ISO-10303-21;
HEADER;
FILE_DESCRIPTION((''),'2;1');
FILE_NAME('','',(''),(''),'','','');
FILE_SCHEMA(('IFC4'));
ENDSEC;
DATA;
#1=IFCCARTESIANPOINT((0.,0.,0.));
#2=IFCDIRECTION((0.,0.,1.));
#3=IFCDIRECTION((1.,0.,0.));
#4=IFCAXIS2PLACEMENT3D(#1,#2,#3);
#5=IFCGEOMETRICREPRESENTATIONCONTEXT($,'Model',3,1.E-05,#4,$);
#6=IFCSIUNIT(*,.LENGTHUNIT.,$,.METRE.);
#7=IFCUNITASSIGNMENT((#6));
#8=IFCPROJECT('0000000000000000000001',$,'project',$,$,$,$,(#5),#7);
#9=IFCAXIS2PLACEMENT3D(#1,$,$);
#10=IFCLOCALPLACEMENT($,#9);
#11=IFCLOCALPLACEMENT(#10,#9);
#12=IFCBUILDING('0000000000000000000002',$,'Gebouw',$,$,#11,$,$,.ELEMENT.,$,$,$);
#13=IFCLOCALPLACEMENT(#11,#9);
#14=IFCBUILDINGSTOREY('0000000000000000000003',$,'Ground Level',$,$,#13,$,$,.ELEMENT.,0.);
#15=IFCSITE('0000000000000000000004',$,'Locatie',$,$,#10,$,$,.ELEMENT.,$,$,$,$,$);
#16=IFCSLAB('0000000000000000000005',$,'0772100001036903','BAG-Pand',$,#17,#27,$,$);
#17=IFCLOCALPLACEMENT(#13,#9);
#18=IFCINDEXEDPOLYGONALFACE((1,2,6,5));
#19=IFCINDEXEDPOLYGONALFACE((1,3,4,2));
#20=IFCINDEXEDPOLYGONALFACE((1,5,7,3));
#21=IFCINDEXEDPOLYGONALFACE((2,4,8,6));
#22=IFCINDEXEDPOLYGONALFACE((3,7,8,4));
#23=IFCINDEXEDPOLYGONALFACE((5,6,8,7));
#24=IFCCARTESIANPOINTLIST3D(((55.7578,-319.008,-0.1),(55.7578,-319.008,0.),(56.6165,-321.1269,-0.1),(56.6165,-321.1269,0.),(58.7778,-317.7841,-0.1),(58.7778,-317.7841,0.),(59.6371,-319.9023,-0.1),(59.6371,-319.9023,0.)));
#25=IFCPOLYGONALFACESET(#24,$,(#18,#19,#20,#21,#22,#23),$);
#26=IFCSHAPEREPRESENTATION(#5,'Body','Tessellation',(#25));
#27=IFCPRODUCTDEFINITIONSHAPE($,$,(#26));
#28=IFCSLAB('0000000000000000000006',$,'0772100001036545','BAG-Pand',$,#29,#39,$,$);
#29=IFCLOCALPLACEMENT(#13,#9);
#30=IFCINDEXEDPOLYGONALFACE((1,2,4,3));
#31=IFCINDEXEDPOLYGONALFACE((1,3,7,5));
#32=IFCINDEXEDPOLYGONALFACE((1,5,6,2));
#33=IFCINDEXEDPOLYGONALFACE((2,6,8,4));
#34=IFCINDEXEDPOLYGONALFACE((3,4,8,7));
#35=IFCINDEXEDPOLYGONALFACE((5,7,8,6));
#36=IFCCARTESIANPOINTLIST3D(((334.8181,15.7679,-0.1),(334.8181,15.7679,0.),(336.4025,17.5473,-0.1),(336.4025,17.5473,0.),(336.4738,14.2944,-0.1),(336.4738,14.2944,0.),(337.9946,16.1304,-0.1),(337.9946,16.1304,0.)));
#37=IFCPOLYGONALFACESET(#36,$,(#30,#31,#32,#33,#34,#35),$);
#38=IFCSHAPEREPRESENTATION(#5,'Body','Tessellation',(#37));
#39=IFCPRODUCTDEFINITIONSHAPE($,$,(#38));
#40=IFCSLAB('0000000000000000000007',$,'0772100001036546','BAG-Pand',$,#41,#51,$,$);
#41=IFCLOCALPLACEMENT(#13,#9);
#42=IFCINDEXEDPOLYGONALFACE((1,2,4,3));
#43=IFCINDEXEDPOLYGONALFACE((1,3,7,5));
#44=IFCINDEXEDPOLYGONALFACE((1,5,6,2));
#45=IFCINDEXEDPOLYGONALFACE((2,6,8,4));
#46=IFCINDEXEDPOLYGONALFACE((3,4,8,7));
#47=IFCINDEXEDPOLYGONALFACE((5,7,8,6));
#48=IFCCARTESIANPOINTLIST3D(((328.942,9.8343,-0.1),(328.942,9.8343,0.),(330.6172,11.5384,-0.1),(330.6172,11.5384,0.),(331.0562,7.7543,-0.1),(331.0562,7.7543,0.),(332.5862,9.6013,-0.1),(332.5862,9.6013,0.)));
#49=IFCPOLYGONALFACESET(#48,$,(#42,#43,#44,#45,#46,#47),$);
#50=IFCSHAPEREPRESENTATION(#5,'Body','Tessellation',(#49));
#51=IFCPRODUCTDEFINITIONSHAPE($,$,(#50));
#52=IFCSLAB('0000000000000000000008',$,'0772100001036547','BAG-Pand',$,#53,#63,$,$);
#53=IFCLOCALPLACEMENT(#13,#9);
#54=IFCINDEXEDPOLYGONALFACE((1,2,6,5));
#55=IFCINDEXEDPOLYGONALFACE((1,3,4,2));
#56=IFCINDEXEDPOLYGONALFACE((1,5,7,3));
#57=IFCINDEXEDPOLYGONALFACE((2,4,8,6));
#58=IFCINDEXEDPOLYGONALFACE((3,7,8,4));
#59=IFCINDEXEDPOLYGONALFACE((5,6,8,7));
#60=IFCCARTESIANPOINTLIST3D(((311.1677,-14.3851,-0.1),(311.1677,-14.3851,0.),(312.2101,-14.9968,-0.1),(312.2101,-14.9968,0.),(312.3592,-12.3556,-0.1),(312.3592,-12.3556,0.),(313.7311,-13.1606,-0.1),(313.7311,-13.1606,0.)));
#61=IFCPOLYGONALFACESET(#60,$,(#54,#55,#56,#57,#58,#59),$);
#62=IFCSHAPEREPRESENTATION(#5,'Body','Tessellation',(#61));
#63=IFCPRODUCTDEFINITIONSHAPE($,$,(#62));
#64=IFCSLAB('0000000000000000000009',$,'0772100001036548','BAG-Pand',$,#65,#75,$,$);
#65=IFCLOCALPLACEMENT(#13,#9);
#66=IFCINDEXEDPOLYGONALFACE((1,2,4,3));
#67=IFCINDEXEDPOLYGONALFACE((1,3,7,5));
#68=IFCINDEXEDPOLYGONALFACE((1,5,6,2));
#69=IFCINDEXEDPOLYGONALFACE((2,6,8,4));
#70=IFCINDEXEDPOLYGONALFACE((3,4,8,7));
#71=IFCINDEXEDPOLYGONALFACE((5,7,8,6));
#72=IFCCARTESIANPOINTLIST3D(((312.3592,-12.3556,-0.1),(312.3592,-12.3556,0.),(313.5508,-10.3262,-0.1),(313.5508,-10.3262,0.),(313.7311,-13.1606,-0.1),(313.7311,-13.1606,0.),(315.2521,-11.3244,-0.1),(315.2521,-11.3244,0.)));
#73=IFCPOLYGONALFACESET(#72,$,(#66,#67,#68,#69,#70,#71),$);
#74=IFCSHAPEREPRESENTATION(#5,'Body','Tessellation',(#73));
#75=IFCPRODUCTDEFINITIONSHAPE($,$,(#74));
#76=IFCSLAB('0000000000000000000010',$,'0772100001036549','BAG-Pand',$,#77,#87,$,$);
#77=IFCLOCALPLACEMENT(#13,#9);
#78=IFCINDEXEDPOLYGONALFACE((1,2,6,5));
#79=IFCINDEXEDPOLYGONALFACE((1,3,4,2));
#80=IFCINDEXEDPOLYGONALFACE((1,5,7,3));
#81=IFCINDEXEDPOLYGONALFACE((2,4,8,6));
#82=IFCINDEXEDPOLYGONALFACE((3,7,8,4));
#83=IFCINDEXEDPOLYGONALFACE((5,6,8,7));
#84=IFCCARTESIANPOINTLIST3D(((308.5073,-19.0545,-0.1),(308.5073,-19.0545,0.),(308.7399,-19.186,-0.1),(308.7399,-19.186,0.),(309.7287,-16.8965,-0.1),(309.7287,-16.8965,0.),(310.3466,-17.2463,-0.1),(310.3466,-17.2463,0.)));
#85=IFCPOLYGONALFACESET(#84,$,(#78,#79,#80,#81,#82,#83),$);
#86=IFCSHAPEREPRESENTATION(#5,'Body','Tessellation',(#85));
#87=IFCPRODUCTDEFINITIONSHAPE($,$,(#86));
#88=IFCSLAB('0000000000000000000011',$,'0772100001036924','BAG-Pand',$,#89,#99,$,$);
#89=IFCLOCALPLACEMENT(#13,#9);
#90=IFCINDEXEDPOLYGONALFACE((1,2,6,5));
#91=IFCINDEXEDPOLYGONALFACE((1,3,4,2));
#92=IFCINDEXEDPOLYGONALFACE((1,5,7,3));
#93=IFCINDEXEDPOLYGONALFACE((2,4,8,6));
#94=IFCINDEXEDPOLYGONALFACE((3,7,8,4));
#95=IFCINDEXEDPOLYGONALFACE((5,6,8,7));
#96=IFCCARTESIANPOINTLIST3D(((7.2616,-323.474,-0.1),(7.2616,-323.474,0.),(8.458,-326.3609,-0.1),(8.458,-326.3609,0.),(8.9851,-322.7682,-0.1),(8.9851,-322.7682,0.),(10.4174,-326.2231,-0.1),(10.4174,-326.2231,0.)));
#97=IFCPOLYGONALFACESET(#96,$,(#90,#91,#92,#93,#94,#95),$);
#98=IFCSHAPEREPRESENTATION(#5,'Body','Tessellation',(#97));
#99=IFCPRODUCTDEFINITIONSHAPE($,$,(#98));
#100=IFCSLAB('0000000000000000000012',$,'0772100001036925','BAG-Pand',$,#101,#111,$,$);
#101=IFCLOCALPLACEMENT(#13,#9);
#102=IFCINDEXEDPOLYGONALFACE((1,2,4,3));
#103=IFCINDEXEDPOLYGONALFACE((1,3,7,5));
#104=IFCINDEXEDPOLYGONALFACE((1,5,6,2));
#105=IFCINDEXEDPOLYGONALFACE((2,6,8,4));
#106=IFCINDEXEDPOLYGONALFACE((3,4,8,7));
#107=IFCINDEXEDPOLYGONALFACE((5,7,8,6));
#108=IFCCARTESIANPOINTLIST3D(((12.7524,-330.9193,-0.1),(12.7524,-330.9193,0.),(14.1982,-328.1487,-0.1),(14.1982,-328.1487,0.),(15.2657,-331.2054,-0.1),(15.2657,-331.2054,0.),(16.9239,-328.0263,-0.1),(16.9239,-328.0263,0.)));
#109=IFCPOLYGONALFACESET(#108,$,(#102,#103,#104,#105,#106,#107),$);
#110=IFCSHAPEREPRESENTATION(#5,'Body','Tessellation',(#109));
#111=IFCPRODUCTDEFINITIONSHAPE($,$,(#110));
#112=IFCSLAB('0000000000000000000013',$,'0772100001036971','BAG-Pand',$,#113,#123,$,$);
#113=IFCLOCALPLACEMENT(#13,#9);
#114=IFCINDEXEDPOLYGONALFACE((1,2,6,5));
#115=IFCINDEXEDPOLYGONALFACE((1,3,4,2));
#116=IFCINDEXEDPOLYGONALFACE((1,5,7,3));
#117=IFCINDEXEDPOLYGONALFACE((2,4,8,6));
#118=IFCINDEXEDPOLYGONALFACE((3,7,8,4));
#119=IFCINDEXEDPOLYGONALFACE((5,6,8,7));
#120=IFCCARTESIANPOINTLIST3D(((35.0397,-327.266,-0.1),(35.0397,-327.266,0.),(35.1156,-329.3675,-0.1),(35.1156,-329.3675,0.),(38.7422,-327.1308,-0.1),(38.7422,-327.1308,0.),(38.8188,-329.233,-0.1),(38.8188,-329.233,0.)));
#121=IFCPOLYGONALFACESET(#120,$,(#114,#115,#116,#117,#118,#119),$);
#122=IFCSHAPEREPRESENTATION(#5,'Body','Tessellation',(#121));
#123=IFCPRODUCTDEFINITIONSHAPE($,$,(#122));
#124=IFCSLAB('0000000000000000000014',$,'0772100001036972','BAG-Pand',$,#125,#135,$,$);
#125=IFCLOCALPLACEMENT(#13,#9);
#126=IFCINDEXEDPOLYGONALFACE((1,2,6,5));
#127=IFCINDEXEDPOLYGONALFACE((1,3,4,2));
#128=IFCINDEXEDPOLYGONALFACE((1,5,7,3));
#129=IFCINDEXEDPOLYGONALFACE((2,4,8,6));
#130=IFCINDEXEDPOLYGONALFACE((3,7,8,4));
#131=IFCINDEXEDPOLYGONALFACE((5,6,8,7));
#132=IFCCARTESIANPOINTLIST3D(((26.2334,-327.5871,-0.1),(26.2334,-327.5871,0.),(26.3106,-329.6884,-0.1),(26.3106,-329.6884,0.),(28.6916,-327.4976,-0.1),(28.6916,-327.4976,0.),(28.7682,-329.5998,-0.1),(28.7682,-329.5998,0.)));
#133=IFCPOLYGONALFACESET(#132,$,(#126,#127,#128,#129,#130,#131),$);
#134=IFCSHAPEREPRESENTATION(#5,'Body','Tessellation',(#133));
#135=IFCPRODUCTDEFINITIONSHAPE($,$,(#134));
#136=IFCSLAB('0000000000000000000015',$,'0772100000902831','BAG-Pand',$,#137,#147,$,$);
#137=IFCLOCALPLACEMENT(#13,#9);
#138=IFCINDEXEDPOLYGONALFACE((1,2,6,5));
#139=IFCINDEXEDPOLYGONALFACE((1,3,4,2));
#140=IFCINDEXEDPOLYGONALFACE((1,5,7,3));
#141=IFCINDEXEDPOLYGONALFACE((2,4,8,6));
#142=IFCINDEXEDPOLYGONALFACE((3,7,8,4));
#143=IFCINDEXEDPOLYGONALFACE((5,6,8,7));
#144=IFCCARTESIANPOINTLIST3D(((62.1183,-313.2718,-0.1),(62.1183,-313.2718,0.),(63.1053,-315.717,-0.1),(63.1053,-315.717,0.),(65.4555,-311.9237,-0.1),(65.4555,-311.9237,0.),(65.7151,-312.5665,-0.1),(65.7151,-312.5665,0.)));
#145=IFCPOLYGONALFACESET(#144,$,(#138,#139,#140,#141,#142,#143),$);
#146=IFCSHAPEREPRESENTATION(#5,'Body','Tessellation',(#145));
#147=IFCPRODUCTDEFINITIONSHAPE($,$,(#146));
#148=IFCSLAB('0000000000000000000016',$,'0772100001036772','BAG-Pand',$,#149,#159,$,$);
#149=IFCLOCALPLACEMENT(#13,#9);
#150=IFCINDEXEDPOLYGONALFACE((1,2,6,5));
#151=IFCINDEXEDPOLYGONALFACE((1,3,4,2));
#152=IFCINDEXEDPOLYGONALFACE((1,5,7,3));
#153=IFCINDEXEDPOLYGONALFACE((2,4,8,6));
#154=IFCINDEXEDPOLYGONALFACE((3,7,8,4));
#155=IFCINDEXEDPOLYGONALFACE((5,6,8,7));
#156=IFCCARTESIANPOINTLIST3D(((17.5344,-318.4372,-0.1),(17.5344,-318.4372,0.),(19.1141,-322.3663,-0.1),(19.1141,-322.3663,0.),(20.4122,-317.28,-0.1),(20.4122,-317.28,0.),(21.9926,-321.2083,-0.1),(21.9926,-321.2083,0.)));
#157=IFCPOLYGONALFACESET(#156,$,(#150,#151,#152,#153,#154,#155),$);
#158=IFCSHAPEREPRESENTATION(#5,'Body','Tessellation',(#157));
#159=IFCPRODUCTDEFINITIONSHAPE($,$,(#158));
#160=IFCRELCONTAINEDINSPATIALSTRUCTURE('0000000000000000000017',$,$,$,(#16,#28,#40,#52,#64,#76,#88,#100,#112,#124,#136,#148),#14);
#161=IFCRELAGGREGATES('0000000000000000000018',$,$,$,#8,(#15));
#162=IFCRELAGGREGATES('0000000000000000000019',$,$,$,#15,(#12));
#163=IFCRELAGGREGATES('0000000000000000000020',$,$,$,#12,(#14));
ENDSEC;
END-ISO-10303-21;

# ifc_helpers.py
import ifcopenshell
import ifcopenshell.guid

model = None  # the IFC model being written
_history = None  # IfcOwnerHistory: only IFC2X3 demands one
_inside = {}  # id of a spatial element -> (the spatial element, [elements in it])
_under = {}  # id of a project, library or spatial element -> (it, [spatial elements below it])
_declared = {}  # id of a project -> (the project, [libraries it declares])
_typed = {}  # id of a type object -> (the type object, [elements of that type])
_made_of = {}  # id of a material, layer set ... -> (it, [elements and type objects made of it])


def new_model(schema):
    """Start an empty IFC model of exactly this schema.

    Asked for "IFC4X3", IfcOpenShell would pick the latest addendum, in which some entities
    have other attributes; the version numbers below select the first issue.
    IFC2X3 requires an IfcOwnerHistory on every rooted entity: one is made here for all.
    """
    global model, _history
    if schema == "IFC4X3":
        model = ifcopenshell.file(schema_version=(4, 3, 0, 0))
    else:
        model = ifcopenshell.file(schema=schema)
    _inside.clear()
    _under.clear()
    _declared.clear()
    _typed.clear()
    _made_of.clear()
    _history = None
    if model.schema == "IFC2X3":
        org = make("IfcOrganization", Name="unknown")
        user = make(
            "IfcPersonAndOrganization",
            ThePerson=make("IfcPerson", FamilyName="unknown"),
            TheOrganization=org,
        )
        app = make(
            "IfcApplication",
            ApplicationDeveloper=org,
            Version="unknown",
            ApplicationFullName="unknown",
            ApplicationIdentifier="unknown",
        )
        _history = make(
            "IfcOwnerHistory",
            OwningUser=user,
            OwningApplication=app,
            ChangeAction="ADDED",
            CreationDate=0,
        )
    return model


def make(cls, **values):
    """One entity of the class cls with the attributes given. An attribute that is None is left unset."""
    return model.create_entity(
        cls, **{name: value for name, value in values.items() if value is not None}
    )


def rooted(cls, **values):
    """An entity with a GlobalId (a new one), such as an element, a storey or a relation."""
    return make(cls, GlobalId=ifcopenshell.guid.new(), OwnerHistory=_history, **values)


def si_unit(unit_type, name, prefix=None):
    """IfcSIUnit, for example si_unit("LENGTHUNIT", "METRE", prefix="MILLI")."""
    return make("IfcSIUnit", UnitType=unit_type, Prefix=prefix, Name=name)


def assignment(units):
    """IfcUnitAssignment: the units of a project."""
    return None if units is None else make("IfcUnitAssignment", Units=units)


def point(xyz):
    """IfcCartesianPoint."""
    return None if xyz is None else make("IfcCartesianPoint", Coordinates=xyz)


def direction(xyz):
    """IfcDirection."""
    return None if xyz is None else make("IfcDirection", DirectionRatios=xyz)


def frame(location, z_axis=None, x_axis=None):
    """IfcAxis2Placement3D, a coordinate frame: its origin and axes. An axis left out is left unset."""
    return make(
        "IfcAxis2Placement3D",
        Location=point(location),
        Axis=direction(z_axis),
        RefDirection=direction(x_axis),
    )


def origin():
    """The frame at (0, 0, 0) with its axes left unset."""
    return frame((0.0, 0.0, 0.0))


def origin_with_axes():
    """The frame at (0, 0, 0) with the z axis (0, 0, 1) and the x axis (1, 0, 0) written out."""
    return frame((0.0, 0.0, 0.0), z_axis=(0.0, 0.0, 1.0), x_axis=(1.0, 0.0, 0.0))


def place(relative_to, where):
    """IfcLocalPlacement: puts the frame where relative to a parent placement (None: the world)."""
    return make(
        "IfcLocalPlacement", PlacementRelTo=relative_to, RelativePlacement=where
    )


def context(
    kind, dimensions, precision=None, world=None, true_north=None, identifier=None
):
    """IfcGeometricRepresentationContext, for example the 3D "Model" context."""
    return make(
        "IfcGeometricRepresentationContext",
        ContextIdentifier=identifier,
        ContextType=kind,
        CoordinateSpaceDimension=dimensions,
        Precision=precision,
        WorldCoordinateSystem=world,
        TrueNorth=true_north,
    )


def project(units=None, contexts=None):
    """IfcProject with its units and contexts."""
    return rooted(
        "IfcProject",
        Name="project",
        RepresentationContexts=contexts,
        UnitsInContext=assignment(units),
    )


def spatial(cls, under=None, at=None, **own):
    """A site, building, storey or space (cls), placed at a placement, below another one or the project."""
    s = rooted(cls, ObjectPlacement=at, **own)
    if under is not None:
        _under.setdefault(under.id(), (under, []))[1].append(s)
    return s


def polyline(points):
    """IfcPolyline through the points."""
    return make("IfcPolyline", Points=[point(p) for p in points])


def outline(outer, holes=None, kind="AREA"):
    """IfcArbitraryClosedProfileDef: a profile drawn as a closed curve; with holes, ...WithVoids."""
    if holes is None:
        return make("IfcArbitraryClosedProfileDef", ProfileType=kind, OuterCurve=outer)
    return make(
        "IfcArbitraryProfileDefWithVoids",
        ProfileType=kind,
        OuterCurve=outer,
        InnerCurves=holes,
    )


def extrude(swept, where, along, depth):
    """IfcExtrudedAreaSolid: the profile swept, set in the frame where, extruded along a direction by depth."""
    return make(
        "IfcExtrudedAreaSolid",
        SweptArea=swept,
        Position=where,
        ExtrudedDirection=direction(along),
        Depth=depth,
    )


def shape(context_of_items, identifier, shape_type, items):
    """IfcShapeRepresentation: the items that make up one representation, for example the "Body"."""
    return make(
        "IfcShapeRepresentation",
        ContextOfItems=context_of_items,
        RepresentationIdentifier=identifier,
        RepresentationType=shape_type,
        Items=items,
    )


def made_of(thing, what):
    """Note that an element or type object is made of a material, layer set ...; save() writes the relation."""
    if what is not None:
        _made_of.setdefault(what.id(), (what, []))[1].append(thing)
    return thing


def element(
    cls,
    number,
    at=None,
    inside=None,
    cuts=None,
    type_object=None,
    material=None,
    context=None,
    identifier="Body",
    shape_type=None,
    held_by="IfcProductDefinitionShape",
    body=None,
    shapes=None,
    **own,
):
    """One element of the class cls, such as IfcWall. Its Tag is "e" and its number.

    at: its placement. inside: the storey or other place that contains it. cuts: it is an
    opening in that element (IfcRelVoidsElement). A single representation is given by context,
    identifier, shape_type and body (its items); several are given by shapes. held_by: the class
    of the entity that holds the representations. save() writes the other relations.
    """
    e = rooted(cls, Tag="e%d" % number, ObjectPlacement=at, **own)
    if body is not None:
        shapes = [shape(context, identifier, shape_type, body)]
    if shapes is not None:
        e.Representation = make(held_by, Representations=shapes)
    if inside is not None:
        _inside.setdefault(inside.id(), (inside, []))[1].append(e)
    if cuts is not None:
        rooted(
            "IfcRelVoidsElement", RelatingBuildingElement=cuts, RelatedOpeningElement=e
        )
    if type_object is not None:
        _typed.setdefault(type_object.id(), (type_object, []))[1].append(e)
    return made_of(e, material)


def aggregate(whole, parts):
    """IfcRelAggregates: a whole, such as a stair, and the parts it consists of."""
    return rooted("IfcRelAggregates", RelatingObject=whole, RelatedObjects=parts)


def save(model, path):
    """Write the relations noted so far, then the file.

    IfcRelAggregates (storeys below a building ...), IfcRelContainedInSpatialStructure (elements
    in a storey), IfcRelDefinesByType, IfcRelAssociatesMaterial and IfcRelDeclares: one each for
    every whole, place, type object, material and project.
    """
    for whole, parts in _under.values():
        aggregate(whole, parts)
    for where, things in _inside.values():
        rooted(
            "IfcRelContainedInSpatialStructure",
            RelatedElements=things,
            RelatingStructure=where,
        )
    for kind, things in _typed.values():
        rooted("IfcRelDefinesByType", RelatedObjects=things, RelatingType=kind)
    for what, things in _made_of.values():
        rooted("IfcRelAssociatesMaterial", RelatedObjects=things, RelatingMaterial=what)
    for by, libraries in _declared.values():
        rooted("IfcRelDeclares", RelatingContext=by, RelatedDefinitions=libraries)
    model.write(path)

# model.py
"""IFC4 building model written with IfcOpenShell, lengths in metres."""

from ifc_helpers import new_model, si_unit, frame, origin, origin_with_axes, place, context, project, spatial, polyline, outline, extrude, element, save


model = new_model("IFC4")

# Units and contexts
model_context = context("Model", 3, precision=1e-05, world=origin_with_axes())
ifc_project = project(units=[si_unit("LENGTHUNIT", "METRE")], contexts=[model_context])

# Site, building, storey
site_placement = place(None, origin())
site = spatial("IfcSite", under=ifc_project, at=site_placement, Name="Locatie", CompositionType="ELEMENT")
building_placement = place(site_placement, origin())
building = spatial("IfcBuilding", under=site, at=building_placement, Name="Gebouw", CompositionType="ELEMENT")
storey_placement = place(building_placement, origin())
storey = spatial("IfcBuildingStorey", under=building, at=storey_placement, Name="Ground Level", CompositionType="ELEMENT", Elevation=0.0)

# Slabs
slab_1_placement = place(storey_placement, origin())
element("IfcSlab", 1, at=slab_1_placement, inside=storey, Name="0772100001036903", Description="BAG-Pand", context=model_context, shape_type="SweptSolid", body=[
    extrude(outline(polyline([(55.7578, -319.008), (58.7778, -317.7841), (59.6371, -319.9023), (56.6165, -321.1269), (55.7578, -319.008)])), frame((0.0, 0.0, -0.1), z_axis=(0.0, 0.0, 1.0), x_axis=(1.0, 0.0, 0.0)), (0.0, 0.0, 1.0), 0.1),
])
slab_2_placement = place(storey_placement, origin())
element("IfcSlab", 2, at=slab_2_placement, inside=storey, Name="0772100001036545", Description="BAG-Pand", context=model_context, shape_type="SweptSolid", body=[
    extrude(outline(polyline([(334.8181, 15.7679), (336.4025, 17.5473), (337.9946, 16.1304), (336.4738, 14.2944), (334.8181, 15.7679)])), frame((0.0, 0.0, -0.1), z_axis=(0.0, 0.0, 1.0), x_axis=(1.0, 0.0, 0.0)), (0.0, 0.0, 1.0), 0.1),
])
slab_3_placement = place(storey_placement, origin())
element("IfcSlab", 3, at=slab_3_placement, inside=storey, Name="0772100001036546", Description="BAG-Pand", context=model_context, shape_type="SweptSolid", body=[
    extrude(outline(polyline([(328.942, 9.8343), (330.6172, 11.5384), (332.5862, 9.6013), (331.0562, 7.7543), (328.942, 9.8343)])), frame((0.0, 0.0, -0.1), z_axis=(0.0, 0.0, 1.0), x_axis=(1.0, 0.0, 0.0)), (0.0, 0.0, 1.0), 0.1),
])
slab_4_placement = place(storey_placement, origin())
element("IfcSlab", 4, at=slab_4_placement, inside=storey, Name="0772100001036547", Description="BAG-Pand", context=model_context, shape_type="SweptSolid", body=[
    extrude(outline(polyline([(311.1677, -14.3851), (312.3592, -12.3556), (313.7311, -13.1606), (312.2101, -14.9968), (311.1677, -14.3851)])), frame((0.0, 0.0, -0.1), z_axis=(0.0, 0.0, 1.0), x_axis=(1.0, 0.0, 0.0)), (0.0, 0.0, 1.0), 0.1),
])
slab_5_placement = place(storey_placement, origin())
element("IfcSlab", 5, at=slab_5_placement, inside=storey, Name="0772100001036548", Description="BAG-Pand", context=model_context, shape_type="SweptSolid", body=[
    extrude(outline(polyline([(312.3592, -12.3556), (313.5508, -10.3262), (315.2521, -11.3244), (313.7311, -13.1606), (312.3592, -12.3556)])), frame((0.0, 0.0, -0.1), z_axis=(0.0, 0.0, 1.0), x_axis=(1.0, 0.0, 0.0)), (0.0, 0.0, 1.0), 0.1),
])
slab_6_placement = place(storey_placement, origin())
element("IfcSlab", 6, at=slab_6_placement, inside=storey, Name="0772100001036549", Description="BAG-Pand", context=model_context, shape_type="SweptSolid", body=[
    extrude(outline(polyline([(308.5073, -19.0545), (309.7287, -16.8965), (310.3466, -17.2463), (308.7399, -19.186), (308.5073, -19.0545)])), frame((0.0, 0.0, -0.1), z_axis=(0.0, 0.0, 1.0), x_axis=(1.0, 0.0, 0.0)), (0.0, 0.0, 1.0), 0.1),
])
slab_7_placement = place(storey_placement, origin())
element("IfcSlab", 7, at=slab_7_placement, inside=storey, Name="0772100001036924", Description="BAG-Pand", context=model_context, shape_type="SweptSolid", body=[
    extrude(outline(polyline([(7.2616, -323.474), (8.9851, -322.7682), (10.4174, -326.2231), (8.458, -326.3609), (7.2616, -323.474)])), frame((0.0, 0.0, -0.1), z_axis=(0.0, 0.0, 1.0), x_axis=(1.0, 0.0, 0.0)), (0.0, 0.0, 1.0), 0.1),
])
slab_8_placement = place(storey_placement, origin())
element("IfcSlab", 8, at=slab_8_placement, inside=storey, Name="0772100001036925", Description="BAG-Pand", context=model_context, shape_type="SweptSolid", body=[
    extrude(outline(polyline([(14.1982, -328.1487), (16.9239, -328.0263), (15.2657, -331.2054), (12.7524, -330.9193), (14.1982, -328.1487)])), frame((0.0, 0.0, -0.1), z_axis=(0.0, 0.0, 1.0), x_axis=(1.0, 0.0, 0.0)), (0.0, 0.0, 1.0), 0.1),
])
slab_9_placement = place(storey_placement, origin())
element("IfcSlab", 9, at=slab_9_placement, inside=storey, Name="0772100001036971", Description="BAG-Pand", context=model_context, shape_type="SweptSolid", body=[
    extrude(outline(polyline([(35.0397, -327.266), (38.7422, -327.1308), (38.8188, -329.233), (35.1156, -329.3675), (35.0397, -327.266)])), frame((0.0, 0.0, -0.1), z_axis=(0.0, 0.0, 1.0), x_axis=(1.0, 0.0, 0.0)), (0.0, 0.0, 1.0), 0.1),
])
slab_10_placement = place(storey_placement, origin())
element("IfcSlab", 10, at=slab_10_placement, inside=storey, Name="0772100001036972", Description="BAG-Pand", context=model_context, shape_type="SweptSolid", body=[
    extrude(outline(polyline([(26.2334, -327.5871), (28.6916, -327.4976), (28.7682, -329.5998), (26.3106, -329.6884), (26.2334, -327.5871)])), frame((0.0, 0.0, -0.1), z_axis=(0.0, 0.0, 1.0), x_axis=(1.0, 0.0, 0.0)), (0.0, 0.0, 1.0), 0.1),
])
slab_11_placement = place(storey_placement, origin())
element("IfcSlab", 11, at=slab_11_placement, inside=storey, Name="0772100000902831", Description="BAG-Pand", context=model_context, shape_type="SweptSolid", body=[
    extrude(outline(polyline([(62.1183, -313.2718), (65.4555, -311.9237), (65.7151, -312.5665), (63.1053, -315.717), (62.1183, -313.2718)])), frame((0.0, 0.0, -0.1), z_axis=(0.0, 0.0, 1.0), x_axis=(1.0, 0.0, 0.0)), (0.0, 0.0, 1.0), 0.1),
])
slab_12_placement = place(storey_placement, origin())
element("IfcSlab", 12, at=slab_12_placement, inside=storey, Name="0772100001036772", Description="BAG-Pand", context=model_context, shape_type="SweptSolid", body=[
    extrude(outline(polyline([(17.5344, -318.4372), (20.4122, -317.28), (21.9926, -321.2083), (19.1141, -322.3663), (17.5344, -318.4372)])), frame((0.0, 0.0, -0.1), z_axis=(0.0, 0.0, 1.0), x_axis=(1.0, 0.0, 0.0)), (0.0, 0.0, 1.0), 0.1),
])

save(model, "model.ifc")
